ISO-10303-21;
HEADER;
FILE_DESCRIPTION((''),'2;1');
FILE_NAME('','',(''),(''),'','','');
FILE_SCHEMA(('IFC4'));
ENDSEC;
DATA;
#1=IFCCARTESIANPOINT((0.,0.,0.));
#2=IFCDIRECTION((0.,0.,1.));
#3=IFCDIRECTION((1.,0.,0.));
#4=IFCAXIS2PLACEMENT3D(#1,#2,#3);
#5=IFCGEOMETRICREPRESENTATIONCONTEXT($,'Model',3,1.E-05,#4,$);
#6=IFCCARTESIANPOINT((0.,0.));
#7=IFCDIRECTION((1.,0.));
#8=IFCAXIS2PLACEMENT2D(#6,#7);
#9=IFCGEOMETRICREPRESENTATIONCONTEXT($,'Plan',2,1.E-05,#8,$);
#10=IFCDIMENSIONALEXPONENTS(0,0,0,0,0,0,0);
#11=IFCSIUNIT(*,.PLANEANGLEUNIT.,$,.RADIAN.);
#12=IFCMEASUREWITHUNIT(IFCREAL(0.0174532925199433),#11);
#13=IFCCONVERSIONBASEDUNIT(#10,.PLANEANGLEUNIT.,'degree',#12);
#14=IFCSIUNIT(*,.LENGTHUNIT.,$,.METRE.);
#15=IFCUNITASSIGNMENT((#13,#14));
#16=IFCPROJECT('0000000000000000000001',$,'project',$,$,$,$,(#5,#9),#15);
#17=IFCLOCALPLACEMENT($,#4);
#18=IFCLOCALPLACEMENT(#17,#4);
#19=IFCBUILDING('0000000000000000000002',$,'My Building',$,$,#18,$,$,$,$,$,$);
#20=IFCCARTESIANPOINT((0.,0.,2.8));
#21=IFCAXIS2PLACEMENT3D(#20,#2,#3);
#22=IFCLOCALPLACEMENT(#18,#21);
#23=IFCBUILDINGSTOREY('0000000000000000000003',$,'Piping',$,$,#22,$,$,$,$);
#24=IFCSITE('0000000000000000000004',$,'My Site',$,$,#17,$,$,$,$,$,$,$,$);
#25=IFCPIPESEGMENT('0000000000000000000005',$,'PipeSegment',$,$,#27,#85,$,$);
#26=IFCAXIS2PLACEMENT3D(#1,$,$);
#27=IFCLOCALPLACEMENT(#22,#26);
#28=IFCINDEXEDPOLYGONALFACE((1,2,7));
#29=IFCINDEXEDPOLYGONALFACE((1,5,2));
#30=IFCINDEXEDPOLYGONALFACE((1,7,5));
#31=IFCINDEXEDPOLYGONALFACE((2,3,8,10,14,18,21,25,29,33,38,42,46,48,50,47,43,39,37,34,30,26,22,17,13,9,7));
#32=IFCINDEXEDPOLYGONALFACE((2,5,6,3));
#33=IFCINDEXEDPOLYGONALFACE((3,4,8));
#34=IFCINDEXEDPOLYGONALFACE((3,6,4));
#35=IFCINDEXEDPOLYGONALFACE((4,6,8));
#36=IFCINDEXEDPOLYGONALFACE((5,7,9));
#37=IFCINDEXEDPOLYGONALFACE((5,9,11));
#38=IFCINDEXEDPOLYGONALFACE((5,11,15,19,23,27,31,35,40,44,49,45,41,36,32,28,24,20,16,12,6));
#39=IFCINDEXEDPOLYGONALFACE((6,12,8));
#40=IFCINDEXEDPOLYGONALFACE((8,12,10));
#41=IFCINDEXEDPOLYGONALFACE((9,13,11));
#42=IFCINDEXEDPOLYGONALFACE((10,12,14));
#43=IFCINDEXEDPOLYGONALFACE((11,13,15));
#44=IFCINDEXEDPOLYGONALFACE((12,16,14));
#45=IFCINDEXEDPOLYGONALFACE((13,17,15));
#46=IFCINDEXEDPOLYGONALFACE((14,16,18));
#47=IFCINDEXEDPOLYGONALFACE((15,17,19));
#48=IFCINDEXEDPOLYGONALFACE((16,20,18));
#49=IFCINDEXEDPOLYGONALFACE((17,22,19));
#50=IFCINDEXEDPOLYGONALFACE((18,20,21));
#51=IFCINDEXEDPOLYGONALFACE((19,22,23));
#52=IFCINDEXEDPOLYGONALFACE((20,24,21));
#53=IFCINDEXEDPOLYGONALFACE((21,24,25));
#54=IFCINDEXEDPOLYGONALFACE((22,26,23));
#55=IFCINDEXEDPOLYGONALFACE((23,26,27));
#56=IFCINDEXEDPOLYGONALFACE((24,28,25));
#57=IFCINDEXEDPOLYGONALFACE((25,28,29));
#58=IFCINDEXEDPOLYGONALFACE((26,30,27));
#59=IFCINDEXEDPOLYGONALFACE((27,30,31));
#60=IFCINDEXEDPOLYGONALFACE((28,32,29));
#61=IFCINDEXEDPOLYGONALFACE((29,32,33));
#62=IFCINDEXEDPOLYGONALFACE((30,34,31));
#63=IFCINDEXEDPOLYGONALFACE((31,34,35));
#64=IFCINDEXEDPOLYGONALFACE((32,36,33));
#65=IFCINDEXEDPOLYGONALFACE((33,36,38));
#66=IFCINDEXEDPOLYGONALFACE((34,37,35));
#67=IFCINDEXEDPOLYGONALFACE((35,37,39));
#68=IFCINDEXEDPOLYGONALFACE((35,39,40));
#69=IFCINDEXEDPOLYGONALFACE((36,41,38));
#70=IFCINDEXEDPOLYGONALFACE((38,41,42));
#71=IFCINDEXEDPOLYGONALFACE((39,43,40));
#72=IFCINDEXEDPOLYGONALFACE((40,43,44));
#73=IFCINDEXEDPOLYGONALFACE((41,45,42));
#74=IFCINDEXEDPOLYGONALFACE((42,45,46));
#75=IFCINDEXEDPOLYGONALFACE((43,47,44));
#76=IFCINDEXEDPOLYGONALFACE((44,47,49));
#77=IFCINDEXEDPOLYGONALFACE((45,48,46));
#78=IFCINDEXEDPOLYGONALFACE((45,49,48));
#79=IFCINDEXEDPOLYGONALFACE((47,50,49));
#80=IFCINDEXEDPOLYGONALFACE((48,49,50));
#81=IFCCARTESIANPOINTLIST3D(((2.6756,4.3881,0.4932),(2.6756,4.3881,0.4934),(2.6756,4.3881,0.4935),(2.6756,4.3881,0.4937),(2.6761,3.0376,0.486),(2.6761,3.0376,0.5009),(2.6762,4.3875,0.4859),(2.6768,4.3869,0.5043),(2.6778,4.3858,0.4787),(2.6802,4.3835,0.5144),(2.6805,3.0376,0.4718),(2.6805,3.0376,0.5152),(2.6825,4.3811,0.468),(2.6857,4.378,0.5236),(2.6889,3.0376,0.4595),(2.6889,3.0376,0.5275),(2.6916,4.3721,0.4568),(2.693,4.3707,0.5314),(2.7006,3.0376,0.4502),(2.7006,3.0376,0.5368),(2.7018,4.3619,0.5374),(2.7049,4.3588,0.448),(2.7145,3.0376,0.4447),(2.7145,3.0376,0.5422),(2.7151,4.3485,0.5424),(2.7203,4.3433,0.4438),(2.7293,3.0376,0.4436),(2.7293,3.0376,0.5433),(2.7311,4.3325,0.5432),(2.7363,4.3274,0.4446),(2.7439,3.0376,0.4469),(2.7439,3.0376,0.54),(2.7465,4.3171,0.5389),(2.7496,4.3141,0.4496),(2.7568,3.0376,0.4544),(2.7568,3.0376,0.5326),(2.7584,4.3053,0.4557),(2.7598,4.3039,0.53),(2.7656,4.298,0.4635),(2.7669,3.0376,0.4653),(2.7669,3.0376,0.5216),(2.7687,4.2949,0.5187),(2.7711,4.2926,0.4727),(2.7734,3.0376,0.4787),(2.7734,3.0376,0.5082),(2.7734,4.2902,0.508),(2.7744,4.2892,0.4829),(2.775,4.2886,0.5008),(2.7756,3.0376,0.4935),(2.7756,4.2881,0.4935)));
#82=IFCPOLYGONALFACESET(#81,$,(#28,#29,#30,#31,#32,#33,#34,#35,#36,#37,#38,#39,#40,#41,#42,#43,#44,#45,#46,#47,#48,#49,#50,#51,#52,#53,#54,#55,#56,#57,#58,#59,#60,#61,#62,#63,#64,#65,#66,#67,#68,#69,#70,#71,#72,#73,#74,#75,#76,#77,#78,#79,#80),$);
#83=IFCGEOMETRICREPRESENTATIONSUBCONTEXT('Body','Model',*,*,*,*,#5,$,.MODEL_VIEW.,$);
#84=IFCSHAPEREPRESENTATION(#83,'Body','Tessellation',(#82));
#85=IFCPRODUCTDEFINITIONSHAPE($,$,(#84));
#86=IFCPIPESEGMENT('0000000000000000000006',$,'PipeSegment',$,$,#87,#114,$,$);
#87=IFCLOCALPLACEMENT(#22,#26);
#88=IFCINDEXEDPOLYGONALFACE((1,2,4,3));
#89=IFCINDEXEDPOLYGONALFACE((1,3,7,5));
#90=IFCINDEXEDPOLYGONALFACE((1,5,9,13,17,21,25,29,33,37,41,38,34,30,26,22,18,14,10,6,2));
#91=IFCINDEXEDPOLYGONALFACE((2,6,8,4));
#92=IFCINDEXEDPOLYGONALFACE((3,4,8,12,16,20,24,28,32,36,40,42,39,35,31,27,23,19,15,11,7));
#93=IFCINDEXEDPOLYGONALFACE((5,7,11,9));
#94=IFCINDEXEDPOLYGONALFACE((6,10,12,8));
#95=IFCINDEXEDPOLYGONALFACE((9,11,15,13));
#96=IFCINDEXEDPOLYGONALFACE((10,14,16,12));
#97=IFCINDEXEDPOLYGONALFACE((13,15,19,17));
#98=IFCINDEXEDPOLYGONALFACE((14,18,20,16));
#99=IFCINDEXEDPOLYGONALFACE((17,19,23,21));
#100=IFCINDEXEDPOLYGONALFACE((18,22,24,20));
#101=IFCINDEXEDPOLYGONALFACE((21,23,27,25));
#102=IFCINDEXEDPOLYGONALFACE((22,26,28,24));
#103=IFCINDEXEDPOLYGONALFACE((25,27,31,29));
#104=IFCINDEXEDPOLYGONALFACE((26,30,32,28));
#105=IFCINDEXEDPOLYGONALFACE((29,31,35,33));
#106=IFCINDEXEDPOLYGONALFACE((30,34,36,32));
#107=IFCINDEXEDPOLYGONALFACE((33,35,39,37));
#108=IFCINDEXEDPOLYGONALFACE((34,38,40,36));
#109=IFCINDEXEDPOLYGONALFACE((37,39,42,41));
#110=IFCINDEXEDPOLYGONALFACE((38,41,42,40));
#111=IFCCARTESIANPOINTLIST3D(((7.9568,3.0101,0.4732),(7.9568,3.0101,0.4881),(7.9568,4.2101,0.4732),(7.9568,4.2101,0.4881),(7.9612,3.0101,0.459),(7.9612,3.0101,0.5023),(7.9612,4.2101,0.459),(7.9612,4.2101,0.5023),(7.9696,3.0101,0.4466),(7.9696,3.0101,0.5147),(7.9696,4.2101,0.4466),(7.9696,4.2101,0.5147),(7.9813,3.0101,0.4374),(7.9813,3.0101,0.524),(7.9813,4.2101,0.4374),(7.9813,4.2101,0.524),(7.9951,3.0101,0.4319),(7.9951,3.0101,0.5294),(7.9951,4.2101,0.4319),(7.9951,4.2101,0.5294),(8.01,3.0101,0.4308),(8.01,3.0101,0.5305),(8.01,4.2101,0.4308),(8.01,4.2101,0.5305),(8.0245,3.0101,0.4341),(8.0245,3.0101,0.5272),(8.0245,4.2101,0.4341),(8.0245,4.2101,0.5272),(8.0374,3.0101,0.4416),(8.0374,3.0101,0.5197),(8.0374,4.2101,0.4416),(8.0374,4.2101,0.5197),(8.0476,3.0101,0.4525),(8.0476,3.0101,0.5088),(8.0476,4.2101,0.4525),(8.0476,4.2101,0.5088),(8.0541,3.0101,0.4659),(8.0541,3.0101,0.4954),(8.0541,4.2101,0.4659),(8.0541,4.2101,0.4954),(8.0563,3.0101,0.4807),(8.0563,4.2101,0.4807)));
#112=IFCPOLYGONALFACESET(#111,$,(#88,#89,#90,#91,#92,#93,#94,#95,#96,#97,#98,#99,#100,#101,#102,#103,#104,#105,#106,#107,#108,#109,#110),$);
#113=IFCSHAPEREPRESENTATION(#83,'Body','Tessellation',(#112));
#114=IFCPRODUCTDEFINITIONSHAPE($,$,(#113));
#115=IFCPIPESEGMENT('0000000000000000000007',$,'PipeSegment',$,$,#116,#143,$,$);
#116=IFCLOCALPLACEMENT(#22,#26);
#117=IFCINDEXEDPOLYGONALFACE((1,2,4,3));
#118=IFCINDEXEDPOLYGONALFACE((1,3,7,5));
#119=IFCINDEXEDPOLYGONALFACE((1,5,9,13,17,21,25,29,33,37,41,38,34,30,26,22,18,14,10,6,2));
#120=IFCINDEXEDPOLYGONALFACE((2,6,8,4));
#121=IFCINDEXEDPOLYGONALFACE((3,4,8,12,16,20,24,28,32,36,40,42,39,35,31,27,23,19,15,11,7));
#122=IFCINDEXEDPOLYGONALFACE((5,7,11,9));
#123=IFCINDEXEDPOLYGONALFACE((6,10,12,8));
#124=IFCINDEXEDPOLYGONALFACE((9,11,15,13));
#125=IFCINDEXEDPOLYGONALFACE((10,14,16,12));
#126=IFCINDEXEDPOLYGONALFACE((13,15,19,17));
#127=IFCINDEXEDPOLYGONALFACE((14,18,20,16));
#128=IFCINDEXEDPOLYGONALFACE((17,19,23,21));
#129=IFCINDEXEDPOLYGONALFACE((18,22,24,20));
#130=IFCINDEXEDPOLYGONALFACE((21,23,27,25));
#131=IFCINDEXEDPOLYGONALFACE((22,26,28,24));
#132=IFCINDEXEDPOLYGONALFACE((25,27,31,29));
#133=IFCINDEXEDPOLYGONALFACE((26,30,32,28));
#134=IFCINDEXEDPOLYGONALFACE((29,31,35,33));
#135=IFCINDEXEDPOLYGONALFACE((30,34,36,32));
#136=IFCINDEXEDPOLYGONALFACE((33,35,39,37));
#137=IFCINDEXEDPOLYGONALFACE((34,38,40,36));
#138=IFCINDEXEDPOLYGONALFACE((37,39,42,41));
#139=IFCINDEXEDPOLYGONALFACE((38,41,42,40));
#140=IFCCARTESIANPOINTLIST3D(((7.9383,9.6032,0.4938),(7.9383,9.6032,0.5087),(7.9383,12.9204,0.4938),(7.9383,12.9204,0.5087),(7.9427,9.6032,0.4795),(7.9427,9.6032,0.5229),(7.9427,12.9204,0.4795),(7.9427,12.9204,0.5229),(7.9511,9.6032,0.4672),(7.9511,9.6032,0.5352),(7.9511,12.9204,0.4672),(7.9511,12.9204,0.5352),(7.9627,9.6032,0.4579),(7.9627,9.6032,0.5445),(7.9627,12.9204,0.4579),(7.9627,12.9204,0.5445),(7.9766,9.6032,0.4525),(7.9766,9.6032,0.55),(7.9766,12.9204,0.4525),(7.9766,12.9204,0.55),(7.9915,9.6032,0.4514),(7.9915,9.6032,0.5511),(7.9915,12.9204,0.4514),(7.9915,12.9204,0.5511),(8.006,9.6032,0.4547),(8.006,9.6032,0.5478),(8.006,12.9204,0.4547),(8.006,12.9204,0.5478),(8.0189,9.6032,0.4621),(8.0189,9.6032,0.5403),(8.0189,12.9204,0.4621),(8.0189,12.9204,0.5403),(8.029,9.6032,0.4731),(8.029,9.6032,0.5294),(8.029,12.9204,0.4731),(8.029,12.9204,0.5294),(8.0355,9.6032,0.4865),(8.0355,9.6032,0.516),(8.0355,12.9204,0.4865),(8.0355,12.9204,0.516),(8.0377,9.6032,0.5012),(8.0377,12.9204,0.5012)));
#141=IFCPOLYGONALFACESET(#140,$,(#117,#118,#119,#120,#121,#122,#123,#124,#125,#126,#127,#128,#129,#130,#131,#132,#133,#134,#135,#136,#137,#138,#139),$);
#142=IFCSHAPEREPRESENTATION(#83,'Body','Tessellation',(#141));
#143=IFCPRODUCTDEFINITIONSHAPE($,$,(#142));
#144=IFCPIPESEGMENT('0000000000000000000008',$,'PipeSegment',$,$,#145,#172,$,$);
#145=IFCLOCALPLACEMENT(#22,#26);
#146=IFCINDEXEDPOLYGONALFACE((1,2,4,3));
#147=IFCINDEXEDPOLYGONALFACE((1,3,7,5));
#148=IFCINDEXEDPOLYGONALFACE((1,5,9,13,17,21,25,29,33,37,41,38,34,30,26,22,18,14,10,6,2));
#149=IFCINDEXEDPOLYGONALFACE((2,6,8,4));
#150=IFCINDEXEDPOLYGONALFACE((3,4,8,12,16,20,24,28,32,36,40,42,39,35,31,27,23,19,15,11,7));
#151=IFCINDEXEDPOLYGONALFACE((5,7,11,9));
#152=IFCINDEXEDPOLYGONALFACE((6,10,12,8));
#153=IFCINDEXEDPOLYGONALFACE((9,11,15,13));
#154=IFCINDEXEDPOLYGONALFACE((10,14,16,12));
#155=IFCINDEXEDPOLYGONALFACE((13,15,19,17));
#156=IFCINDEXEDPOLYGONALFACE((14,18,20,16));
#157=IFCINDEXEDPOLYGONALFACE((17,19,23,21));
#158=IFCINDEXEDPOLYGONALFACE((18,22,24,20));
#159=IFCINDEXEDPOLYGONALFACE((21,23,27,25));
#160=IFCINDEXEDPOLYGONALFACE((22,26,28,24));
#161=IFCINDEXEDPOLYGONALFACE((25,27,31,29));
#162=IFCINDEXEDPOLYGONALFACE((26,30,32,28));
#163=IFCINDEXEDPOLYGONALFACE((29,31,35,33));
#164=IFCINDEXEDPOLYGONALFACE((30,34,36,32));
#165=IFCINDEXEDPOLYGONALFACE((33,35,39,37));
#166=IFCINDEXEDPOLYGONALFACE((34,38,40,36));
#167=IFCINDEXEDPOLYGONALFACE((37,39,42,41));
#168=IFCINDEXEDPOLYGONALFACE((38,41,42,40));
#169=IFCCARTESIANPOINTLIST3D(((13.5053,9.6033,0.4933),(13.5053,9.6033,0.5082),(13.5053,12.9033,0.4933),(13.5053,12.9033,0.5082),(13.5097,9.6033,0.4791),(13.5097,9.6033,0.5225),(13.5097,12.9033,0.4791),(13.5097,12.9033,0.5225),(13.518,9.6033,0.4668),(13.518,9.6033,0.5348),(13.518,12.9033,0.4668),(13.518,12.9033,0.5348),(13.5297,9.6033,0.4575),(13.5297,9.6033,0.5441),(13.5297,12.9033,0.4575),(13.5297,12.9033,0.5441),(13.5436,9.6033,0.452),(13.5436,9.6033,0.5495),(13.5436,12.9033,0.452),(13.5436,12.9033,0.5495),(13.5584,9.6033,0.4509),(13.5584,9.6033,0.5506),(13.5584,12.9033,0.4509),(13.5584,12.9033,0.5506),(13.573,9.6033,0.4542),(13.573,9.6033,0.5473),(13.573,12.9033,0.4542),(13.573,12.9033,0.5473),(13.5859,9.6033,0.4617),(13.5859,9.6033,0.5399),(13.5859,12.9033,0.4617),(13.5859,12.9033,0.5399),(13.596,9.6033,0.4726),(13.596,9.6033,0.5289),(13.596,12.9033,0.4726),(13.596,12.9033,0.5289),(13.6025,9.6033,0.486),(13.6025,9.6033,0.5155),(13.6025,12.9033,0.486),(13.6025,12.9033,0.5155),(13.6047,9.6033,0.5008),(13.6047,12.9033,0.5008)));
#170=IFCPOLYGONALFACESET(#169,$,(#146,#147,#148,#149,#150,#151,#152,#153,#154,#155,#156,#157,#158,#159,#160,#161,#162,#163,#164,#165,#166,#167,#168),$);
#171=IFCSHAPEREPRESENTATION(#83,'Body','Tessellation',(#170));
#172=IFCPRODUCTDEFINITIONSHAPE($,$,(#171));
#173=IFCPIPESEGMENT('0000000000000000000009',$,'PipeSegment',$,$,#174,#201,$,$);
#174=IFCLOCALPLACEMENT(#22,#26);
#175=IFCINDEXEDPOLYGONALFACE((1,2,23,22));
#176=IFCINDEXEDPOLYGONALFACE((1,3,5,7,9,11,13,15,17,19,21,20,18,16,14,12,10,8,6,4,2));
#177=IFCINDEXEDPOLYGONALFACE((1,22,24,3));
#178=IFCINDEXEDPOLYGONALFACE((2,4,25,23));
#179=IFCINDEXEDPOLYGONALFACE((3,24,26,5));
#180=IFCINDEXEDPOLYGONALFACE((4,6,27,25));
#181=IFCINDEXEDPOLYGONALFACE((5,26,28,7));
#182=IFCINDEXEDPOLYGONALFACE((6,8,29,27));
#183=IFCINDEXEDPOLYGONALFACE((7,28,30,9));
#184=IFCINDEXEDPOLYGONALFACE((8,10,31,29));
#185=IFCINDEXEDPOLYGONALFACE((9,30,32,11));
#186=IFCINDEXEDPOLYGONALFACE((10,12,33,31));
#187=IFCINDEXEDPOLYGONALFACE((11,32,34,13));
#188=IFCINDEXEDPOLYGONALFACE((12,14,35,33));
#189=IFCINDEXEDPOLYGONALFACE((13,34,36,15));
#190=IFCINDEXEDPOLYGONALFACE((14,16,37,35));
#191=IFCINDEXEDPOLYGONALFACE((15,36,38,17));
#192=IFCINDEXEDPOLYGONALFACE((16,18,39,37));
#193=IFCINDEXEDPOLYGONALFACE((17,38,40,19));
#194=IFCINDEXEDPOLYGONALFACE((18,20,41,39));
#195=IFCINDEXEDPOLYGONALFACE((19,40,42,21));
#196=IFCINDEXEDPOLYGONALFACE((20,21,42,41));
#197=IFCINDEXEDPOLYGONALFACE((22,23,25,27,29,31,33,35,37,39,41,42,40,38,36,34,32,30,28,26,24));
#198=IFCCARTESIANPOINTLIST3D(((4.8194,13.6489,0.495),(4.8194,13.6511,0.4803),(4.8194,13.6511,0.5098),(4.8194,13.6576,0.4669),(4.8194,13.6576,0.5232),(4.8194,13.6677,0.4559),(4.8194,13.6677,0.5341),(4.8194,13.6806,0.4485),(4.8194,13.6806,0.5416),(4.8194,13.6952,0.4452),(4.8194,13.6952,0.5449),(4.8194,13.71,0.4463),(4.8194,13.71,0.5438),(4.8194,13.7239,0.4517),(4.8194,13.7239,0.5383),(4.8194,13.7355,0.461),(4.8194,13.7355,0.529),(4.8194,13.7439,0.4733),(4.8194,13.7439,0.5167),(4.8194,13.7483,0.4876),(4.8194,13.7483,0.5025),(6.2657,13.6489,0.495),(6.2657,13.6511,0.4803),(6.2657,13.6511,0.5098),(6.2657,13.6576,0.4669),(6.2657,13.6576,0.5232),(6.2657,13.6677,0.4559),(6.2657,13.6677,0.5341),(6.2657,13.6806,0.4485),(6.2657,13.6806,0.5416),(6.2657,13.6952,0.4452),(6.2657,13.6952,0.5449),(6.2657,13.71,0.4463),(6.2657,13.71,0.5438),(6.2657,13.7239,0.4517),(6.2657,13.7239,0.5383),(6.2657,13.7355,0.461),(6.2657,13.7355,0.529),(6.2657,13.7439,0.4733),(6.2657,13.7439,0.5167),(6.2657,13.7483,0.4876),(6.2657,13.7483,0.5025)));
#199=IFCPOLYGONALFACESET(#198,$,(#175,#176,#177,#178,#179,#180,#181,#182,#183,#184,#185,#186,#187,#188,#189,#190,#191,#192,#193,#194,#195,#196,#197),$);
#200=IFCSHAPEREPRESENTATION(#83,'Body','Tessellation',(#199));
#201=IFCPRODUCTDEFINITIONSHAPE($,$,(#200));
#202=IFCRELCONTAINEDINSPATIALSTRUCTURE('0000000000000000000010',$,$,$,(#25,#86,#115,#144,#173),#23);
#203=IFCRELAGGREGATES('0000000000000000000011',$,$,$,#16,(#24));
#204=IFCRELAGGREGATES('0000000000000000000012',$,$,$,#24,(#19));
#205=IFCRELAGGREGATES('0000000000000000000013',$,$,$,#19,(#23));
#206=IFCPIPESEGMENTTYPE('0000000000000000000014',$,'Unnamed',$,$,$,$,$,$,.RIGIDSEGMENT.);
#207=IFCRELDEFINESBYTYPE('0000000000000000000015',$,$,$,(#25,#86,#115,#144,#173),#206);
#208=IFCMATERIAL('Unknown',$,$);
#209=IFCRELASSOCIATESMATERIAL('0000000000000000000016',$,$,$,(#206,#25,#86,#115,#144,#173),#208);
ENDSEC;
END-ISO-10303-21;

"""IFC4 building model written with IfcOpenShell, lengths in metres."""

from ifc_helpers import new_model, entity, si_unit, converted_unit, frame, origin_with_axes, origin_2d_with_axis, place, context, subcontext, project, spatial, circle, extrude, clip, halfspace, material, material_profile, profile_set, profile_usage, type_object, element, save


model = new_model("IFC4")

# Units and contexts
model_context = context("Model", 3, precision=1e-05, world=origin_with_axes())
plan_context = context("Plan", 2, precision=1e-05, world=origin_2d_with_axis())
body_context = subcontext(model_context, "Body", "Model", "MODEL_VIEW")
ifc_project = project(units=[converted_unit("PLANEANGLEUNIT", "degree", entity("IfcReal", 0.0174532925199433), si_unit("PLANEANGLEUNIT", "RADIAN"), dimensions=[0, 0, 0, 0, 0, 0, 0]), si_unit("LENGTHUNIT", "METRE")], contexts=[model_context, plan_context])

# Site, building, storey
site_placement = place(None, origin_with_axes())
site = spatial("IfcSite", under=ifc_project, at=site_placement, Name="My Site")
building_placement = place(site_placement, origin_with_axes())
building = spatial("IfcBuilding", under=site, at=building_placement, Name="My Building")
storey_placement = place(building_placement, frame((0.0, 0.0, 2.8), z_axis=(0.0, 0.0, 1.0), x_axis=(1.0, 0.0, 0.0)))
storey = spatial("IfcBuildingStorey", under=building, at=storey_placement, Name="Piping")

# Pipe segments
ifc_material = material(Name="Unknown")
ifc_material_profile_1 = material_profile(ifc_material, circle(Radius=0.05))
ifc_profile_set_1 = profile_set([ifc_material_profile_1])
pipe_segment_type = type_object("IfcPipeSegmentType", Name="Unnamed", PredefinedType="RIGIDSEGMENT", material=ifc_profile_set_1)
ifc_profile_usage_1 = profile_usage(ifc_profile_set_1, cardinal=5)
pipe_segment_1_placement = place(storey_placement, frame((2.7256, 4.3881, 0.4935), z_axis=(0.0, -1.0, 0.0), x_axis=(1.0, 0.0, 0.0)))
element("IfcPipeSegment", 1, at=pipe_segment_1_placement, inside=storey, type_object=pipe_segment_type, material=ifc_profile_usage_1, Name="PipeSegment", context=body_context, shape_type="Clipping", body=[
    clip(extrude(circle(Radius=0.05), origin_with_axes(), (0.0, 0.0, 1.0), 1.3505), halfspace(frame((-0.05, -0.0499, 0.0), z_axis=(0.707108, 0.0, -0.707105), x_axis=(0.0, -1.0, 0.0)), False)),
])
ifc_profile_usage_2 = profile_usage(ifc_profile_set_1, cardinal=5)
pipe_segment_2_placement = place(storey_placement, frame((8.0063, 4.2101, 0.4807), z_axis=(0.0, -1.0, 0.0), x_axis=(1.0, 0.0, 0.0)))
element("IfcPipeSegment", 2, at=pipe_segment_2_placement, inside=storey, type_object=pipe_segment_type, material=ifc_profile_usage_2, Name="PipeSegment", context=body_context, shape_type="SweptSolid", body=[
    extrude(circle(Radius=0.05), origin_with_axes(), (0.0, 0.0, 1.0), 1.2),
])
ifc_profile_usage_3 = profile_usage(ifc_profile_set_1, cardinal=5)
pipe_segment_3_placement = place(storey_placement, frame((7.9877, 12.9204, 0.5012), z_axis=(0.0, -1.0, 0.0), x_axis=(1.0, 0.0, 0.0)))
element("IfcPipeSegment", 3, at=pipe_segment_3_placement, inside=storey, type_object=pipe_segment_type, material=ifc_profile_usage_3, Name="PipeSegment", context=body_context, shape_type="SweptSolid", body=[
    extrude(circle(Radius=0.05), origin_with_axes(), (0.0, 0.0, 1.0), 3.3172),
])
ifc_profile_usage_4 = profile_usage(ifc_profile_set_1, cardinal=5)
pipe_segment_4_placement = place(storey_placement, frame((13.5547, 12.9033, 0.5008), z_axis=(0.0, -1.0, 0.0), x_axis=(1.0, 0.0, 0.0)))
element("IfcPipeSegment", 4, at=pipe_segment_4_placement, inside=storey, type_object=pipe_segment_type, material=ifc_profile_usage_4, Name="PipeSegment", context=body_context, shape_type="SweptSolid", body=[
    extrude(circle(Radius=0.05), origin_with_axes(), (0.0, 0.0, 1.0), 3.3),
])
ifc_profile_usage_5 = profile_usage(ifc_profile_set_1, cardinal=5)
pipe_segment_5_placement = place(storey_placement, frame((6.2657, 13.6989, 0.495), z_axis=(-1.0, 0.0, 0.0), x_axis=(0.0, -1.0, 0.0)))
element("IfcPipeSegment", 5, at=pipe_segment_5_placement, inside=storey, type_object=pipe_segment_type, material=ifc_profile_usage_5, Name="PipeSegment", context=body_context, shape_type="SweptSolid", body=[
    extrude(circle(Radius=0.05), origin_with_axes(), (0.0, 0.0, 1.0), 1.4463),
])

save(model, "model.ifc")
